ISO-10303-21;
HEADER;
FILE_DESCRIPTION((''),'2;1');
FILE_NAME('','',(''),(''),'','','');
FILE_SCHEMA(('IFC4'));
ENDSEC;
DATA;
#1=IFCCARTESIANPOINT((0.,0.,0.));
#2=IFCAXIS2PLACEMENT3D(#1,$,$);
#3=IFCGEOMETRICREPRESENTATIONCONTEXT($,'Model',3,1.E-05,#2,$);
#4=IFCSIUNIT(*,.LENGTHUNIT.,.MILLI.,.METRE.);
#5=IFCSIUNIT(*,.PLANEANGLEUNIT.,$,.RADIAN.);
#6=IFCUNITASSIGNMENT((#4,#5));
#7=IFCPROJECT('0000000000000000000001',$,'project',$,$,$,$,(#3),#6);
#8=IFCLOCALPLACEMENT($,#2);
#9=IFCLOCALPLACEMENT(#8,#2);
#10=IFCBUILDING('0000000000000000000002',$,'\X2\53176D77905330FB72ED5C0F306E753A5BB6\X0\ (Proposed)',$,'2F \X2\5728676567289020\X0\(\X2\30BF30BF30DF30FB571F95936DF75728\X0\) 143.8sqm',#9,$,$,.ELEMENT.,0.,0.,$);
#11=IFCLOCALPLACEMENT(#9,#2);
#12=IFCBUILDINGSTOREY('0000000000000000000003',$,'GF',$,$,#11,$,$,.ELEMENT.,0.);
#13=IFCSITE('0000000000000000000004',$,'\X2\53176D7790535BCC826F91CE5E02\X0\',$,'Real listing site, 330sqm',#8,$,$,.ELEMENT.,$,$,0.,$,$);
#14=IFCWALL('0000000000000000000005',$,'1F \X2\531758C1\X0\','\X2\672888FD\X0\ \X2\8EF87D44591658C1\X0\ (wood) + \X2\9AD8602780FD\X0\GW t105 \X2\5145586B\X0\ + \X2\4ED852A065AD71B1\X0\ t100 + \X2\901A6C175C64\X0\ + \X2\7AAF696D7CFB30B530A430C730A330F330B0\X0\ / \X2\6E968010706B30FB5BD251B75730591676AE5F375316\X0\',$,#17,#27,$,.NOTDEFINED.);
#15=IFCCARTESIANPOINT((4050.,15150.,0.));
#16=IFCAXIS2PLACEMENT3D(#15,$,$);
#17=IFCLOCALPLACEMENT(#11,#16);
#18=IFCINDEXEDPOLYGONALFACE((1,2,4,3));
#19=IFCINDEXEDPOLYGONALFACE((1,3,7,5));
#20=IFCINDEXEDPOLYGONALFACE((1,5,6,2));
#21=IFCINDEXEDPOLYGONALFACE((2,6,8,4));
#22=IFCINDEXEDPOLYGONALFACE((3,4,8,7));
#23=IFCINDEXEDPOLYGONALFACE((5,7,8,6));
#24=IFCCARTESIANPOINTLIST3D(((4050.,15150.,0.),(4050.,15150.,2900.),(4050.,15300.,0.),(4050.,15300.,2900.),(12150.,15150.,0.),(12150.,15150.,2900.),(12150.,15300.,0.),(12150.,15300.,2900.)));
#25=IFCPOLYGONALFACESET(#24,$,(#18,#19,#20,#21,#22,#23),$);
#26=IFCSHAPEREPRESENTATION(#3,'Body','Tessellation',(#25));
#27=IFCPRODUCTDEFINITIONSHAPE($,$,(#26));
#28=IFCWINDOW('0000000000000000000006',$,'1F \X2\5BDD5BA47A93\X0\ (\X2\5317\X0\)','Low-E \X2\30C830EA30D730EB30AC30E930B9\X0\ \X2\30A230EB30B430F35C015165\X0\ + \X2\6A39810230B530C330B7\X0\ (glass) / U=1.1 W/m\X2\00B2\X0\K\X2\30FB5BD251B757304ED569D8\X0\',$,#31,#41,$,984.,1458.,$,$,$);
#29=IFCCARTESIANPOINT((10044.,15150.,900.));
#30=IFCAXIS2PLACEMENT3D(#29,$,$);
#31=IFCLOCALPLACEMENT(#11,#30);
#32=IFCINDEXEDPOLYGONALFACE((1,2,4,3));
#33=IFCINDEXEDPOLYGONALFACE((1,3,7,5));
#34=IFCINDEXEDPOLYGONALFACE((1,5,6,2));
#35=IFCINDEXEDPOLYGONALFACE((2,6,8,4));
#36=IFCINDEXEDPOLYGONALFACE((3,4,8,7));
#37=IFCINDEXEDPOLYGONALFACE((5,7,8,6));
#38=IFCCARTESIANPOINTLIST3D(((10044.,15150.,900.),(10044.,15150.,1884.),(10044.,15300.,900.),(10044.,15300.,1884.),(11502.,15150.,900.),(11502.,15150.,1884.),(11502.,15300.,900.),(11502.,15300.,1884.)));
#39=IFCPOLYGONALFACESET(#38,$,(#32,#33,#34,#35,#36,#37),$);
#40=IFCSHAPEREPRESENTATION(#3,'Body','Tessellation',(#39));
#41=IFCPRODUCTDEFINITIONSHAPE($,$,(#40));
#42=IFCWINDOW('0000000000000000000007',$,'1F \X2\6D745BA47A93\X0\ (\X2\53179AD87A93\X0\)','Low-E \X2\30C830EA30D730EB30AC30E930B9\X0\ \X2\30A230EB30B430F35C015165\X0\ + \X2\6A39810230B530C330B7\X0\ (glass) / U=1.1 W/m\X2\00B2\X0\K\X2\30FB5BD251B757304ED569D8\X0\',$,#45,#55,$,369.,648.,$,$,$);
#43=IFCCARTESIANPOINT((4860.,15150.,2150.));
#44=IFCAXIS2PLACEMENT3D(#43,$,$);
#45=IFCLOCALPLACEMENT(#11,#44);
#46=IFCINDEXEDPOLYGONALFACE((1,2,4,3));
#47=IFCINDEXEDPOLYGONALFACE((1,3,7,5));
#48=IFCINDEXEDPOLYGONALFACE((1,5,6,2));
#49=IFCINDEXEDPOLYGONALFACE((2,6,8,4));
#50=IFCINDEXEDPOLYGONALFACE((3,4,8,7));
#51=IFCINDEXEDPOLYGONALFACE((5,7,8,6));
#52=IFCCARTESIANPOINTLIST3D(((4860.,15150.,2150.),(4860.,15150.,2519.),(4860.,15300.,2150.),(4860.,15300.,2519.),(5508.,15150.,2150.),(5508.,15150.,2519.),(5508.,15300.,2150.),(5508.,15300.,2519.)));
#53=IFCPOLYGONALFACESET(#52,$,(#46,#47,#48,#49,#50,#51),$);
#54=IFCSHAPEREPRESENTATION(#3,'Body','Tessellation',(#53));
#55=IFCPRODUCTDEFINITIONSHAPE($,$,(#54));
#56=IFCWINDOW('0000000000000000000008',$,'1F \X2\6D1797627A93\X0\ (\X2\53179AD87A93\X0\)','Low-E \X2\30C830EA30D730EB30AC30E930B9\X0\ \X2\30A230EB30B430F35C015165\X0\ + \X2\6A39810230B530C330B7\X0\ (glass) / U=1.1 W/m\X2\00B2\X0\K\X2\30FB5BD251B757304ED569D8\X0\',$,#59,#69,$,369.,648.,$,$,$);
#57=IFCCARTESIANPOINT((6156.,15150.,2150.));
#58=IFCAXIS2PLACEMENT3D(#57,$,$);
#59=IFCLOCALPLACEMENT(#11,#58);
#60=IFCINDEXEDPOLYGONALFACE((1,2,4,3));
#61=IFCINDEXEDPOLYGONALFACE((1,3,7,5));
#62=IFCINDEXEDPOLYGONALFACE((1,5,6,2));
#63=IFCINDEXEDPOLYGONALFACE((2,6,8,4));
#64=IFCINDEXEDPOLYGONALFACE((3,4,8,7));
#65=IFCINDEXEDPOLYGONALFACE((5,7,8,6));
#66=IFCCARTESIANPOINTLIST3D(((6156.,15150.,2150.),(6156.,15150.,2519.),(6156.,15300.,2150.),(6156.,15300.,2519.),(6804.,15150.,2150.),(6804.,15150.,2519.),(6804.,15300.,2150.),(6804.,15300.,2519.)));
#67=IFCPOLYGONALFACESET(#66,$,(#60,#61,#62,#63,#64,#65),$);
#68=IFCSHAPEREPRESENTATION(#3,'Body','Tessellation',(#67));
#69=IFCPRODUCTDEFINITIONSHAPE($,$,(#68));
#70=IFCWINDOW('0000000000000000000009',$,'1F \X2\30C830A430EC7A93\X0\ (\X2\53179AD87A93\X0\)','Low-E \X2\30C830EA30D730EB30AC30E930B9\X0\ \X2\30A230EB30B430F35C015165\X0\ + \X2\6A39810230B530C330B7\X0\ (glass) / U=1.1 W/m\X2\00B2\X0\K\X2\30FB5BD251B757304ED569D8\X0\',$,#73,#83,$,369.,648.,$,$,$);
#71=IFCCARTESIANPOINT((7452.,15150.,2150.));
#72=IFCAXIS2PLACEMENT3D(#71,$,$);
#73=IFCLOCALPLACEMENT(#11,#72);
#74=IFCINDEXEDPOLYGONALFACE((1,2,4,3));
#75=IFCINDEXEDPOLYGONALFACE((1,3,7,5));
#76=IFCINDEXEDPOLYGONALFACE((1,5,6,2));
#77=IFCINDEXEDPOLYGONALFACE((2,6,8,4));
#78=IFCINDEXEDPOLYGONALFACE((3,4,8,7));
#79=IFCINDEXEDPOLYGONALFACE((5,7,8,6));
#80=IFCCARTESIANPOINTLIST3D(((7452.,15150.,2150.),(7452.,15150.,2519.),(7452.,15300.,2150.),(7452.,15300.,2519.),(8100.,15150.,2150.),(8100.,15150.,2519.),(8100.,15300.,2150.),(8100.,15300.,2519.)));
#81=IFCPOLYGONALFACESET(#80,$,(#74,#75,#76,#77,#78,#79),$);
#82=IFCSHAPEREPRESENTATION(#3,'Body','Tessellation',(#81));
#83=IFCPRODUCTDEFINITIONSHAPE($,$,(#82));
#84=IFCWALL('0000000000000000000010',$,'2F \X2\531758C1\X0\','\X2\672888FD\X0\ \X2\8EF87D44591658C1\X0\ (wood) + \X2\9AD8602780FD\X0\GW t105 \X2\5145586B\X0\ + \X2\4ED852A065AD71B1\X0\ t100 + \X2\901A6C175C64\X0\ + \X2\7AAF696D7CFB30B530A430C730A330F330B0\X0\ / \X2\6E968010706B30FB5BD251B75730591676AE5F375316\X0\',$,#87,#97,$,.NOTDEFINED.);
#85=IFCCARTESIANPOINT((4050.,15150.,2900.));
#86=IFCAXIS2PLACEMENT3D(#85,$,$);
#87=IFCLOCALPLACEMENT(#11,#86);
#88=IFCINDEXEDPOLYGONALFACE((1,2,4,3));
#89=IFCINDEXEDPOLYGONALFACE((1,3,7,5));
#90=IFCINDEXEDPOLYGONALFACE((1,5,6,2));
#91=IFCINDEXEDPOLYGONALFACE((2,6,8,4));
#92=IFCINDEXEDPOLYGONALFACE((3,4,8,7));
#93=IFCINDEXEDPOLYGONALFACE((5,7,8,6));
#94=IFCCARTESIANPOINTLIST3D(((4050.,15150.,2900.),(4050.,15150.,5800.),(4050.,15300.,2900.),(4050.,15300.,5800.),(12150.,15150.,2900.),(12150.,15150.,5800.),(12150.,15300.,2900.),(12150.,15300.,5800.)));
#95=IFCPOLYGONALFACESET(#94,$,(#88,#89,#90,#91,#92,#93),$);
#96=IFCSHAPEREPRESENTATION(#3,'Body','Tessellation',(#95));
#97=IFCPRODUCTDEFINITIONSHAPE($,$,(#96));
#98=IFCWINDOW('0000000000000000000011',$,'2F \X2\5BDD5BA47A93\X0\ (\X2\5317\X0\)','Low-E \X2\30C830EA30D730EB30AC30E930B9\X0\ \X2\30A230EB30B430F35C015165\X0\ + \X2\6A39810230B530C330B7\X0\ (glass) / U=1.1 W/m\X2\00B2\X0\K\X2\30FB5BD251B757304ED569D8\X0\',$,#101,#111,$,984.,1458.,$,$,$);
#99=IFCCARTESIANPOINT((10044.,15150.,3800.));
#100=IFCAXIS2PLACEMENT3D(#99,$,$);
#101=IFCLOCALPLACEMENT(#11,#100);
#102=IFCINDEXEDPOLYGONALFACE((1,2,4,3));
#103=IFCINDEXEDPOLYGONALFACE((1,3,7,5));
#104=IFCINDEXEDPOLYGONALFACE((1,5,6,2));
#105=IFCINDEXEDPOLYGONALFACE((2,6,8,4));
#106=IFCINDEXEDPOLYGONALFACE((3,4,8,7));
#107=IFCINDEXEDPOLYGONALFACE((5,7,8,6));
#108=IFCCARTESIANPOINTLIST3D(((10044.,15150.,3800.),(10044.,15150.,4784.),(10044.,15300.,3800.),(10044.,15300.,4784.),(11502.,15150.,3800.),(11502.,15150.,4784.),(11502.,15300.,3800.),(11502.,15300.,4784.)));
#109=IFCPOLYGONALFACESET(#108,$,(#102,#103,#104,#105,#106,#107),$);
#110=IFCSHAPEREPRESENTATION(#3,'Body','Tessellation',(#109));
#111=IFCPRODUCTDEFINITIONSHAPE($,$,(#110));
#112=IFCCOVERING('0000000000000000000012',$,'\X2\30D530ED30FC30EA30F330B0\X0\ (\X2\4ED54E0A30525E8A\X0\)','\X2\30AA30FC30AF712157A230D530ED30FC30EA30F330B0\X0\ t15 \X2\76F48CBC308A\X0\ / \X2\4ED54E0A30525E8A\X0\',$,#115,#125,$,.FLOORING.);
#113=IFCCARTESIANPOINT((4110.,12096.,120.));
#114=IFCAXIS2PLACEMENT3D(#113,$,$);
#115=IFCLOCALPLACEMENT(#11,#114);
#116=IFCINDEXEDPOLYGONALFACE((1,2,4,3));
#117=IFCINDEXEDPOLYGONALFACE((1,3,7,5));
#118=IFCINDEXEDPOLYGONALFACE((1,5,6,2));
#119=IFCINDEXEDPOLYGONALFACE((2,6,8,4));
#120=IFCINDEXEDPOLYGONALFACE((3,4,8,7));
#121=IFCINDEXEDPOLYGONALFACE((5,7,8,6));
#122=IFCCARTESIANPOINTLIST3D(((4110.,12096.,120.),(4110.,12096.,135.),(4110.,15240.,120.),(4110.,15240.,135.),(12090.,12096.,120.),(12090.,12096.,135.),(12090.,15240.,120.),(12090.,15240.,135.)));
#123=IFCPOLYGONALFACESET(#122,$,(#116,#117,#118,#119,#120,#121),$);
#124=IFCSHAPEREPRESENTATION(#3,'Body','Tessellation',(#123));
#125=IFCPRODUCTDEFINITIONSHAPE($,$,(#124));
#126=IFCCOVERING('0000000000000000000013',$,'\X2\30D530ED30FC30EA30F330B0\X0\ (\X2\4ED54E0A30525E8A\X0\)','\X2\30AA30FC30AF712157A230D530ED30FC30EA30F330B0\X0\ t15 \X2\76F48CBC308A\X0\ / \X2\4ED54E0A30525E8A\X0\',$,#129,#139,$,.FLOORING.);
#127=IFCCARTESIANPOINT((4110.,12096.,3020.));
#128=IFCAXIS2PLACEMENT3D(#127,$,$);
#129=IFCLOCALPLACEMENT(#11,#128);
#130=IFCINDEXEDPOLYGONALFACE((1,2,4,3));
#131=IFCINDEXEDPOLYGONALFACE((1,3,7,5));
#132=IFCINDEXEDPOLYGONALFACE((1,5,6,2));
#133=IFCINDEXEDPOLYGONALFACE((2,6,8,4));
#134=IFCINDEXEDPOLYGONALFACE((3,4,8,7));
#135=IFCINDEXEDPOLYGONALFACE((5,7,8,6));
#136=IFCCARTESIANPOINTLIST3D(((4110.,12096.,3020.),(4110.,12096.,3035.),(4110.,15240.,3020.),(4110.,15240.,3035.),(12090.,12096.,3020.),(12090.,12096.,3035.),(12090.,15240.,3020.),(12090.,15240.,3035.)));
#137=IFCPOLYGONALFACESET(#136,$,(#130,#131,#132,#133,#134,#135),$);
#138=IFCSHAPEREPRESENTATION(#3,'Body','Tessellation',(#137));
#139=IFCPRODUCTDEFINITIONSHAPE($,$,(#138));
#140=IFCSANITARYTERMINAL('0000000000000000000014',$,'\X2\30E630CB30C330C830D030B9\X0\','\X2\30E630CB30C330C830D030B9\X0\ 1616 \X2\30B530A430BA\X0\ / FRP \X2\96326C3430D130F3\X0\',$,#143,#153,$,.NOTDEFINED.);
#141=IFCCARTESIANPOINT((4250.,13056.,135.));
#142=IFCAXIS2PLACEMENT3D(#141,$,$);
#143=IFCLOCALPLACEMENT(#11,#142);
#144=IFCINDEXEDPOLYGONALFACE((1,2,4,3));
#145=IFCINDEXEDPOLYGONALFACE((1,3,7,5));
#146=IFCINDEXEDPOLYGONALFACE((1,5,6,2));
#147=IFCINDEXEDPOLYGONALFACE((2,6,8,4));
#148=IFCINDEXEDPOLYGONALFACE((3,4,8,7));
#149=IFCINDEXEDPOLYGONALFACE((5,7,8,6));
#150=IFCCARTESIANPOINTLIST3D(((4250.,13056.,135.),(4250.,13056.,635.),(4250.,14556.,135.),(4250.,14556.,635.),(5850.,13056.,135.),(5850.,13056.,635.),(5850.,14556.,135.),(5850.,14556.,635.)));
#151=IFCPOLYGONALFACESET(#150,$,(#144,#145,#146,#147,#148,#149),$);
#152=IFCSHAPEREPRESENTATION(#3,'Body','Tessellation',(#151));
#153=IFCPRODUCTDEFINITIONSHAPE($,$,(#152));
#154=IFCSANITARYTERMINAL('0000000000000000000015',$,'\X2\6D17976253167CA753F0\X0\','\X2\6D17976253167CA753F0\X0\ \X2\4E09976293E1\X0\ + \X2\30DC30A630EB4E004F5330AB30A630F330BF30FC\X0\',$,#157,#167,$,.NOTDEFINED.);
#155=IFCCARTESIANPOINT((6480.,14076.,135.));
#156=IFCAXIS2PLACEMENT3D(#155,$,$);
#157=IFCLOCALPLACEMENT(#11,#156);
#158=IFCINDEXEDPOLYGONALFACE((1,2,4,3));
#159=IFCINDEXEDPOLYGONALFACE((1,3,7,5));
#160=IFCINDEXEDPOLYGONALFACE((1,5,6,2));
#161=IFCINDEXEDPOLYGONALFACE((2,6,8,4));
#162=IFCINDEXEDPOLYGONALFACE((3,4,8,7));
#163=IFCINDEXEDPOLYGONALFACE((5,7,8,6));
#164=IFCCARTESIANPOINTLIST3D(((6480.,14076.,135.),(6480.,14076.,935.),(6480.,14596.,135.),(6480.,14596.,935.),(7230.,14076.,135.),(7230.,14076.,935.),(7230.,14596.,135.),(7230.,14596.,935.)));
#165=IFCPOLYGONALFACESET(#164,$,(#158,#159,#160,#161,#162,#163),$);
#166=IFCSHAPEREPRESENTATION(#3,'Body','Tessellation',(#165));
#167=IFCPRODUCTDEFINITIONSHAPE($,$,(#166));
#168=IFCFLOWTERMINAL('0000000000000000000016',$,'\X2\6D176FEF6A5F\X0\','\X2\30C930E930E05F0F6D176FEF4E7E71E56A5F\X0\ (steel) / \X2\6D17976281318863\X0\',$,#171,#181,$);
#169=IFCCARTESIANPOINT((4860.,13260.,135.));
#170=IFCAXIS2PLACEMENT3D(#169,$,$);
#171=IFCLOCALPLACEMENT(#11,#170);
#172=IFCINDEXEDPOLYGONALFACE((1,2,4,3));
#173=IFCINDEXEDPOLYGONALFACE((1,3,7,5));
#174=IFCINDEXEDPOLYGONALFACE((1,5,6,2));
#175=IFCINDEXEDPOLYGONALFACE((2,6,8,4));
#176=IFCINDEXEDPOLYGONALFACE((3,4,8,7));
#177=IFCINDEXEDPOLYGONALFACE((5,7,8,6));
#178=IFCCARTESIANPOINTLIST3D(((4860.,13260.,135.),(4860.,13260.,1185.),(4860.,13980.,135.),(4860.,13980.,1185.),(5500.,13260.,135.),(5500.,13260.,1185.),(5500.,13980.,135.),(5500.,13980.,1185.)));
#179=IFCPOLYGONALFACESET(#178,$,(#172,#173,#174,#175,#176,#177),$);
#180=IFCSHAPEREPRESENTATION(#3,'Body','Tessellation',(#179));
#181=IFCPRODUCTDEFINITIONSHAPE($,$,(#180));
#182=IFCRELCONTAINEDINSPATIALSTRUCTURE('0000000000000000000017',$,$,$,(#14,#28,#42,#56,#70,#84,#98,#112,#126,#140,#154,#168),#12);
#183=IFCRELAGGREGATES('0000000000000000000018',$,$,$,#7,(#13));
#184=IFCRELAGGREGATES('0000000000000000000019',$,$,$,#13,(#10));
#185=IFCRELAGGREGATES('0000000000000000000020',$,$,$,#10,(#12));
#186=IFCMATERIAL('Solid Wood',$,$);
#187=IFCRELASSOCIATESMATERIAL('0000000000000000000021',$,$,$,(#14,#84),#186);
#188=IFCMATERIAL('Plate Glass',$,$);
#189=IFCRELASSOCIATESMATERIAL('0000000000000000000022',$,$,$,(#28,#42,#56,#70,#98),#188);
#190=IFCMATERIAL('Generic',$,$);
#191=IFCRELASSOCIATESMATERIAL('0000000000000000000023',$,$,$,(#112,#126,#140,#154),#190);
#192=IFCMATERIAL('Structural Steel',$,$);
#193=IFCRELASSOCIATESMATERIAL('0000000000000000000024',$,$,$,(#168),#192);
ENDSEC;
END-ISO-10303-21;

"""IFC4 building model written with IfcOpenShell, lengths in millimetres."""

from ifc_helpers import new_model, si_unit, frame, frame_2d, origin, place, context, project, spatial, rectangle, extrude, material, element, fill, save


model = new_model("IFC4")

# Units and contexts
model_context = context("Model", 3, precision=1e-05, world=origin())
ifc_project = project(units=[si_unit("LENGTHUNIT", "METRE", prefix="MILLI"), si_unit("PLANEANGLEUNIT", "RADIAN")], contexts=[model_context])

# Site, building, storey
site_placement = place(None, origin())
site = spatial("IfcSite", under=ifc_project, at=site_placement, Name="北海道富良野市", ObjectType="Real listing site, 330sqm", CompositionType="ELEMENT", RefElevation=0.0)
building_placement = place(site_placement, origin())
building = spatial("IfcBuilding", under=site, at=building_placement, Name="北海道・狭小の町家 (Proposed)", ObjectType="2F 在来木造(タタミ・土間混在) 143.8sqm", CompositionType="ELEMENT", ElevationOfRefHeight=0.0, ElevationOfTerrain=0.0)
storey_placement = place(building_placement, origin())
storey = spatial("IfcBuildingStorey", under=building, at=storey_placement, Name="GF", CompositionType="ELEMENT", Elevation=0.0)

# Shared definitions
ifc_material_1 = material(Name="Solid Wood")

# Wall, openings, windows
wall_1_placement = place(storey_placement, frame((4050.0, 15150.0, 0.0)))
wall_1 = element("IfcWall", 1, at=wall_1_placement, inside=storey, material=ifc_material_1, Name="1F 北壁", Description="木製 軸組外壁 (wood) + 高性能GW t105 充填 + 付加断熱 t100 + 通気層 + 窯業系サイディング / 準耐火・寒冷地外皮強化", PredefinedType="NOTDEFINED", context=model_context, shape_type="SweptSolid", body=[
    extrude(rectangle(XDim=8100.0, YDim=150.0, at=frame_2d((4050.0, 75.0))), frame((4050.0, 15150.0, 0.0)), (0.0, 0.0, 1.0), 2900.0),
])
opening_1_placement = place(storey_placement, frame((10044.0, 15150.0, 900.0)))
opening_1 = element("IfcOpeningElement", 2, at=opening_1_placement, cuts=wall_1, PredefinedType="NOTDEFINED", context=model_context, shape_type="SweptSolid", body=[
    extrude(rectangle(XDim=1458.0, YDim=150.0, at=frame_2d((729.0, 75.0))), frame((10044.0, 15150.0, 900.0)), (0.0, 0.0, 1.0), 984.0),
])
opening_2_placement = place(storey_placement, frame((4860.0, 15150.0, 2150.0)))
opening_2 = element("IfcOpeningElement", 3, at=opening_2_placement, cuts=wall_1, PredefinedType="NOTDEFINED", context=model_context, shape_type="SweptSolid", body=[
    extrude(rectangle(XDim=648.0, YDim=150.0, at=frame_2d((324.0, 75.0))), frame((4860.0, 15150.0, 2150.0)), (0.0, 0.0, 1.0), 369.0),
])
opening_3_placement = place(storey_placement, frame((6156.0, 15150.0, 2150.0)))
opening_3 = element("IfcOpeningElement", 4, at=opening_3_placement, cuts=wall_1, PredefinedType="NOTDEFINED", context=model_context, shape_type="SweptSolid", body=[
    extrude(rectangle(XDim=648.0, YDim=150.0, at=frame_2d((324.0, 75.0))), frame((6156.0, 15150.0, 2150.0)), (0.0, 0.0, 1.0), 369.0),
])
opening_4_placement = place(storey_placement, frame((7452.0, 15150.0, 2150.0)))
opening_4 = element("IfcOpeningElement", 5, at=opening_4_placement, cuts=wall_1, PredefinedType="NOTDEFINED", context=model_context, shape_type="SweptSolid", body=[
    extrude(rectangle(XDim=648.0, YDim=150.0, at=frame_2d((324.0, 75.0))), frame((7452.0, 15150.0, 2150.0)), (0.0, 0.0, 1.0), 369.0),
])
ifc_material_2 = material(Name="Plate Glass")
window_1_placement = place(storey_placement, frame((10044.0, 15150.0, 900.0)))
window_1 = element("IfcWindow", 6, at=window_1_placement, inside=storey, material=ifc_material_2, Name="1F 寝室窓 (北)", Description="Low-E トリプルガラス アルゴン封入 + 樹脂サッシ (glass) / U=1.1 W/m²K・寒冷地仕様", OverallHeight=984.0, OverallWidth=1458.0, context=model_context, shape_type="SweptSolid", body=[
    extrude(rectangle(XDim=1458.0, YDim=150.0, at=frame_2d((729.0, 75.0))), frame((10044.0, 15150.0, 900.0)), (0.0, 0.0, 1.0), 984.0),
])
fill(opening_1, window_1)
window_2_placement = place(storey_placement, frame((4860.0, 15150.0, 2150.0)))
window_2 = element("IfcWindow", 7, at=window_2_placement, inside=storey, material=ifc_material_2, Name="1F 浴室窓 (北高窓)", Description="Low-E トリプルガラス アルゴン封入 + 樹脂サッシ (glass) / U=1.1 W/m²K・寒冷地仕様", OverallHeight=369.0, OverallWidth=648.0, context=model_context, shape_type="SweptSolid", body=[
    extrude(rectangle(XDim=648.0, YDim=150.0, at=frame_2d((324.0, 75.0))), frame((4860.0, 15150.0, 2150.0)), (0.0, 0.0, 1.0), 369.0),
])
fill(opening_2, window_2)
window_3_placement = place(storey_placement, frame((6156.0, 15150.0, 2150.0)))
window_3 = element("IfcWindow", 8, at=window_3_placement, inside=storey, material=ifc_material_2, Name="1F 洗面窓 (北高窓)", Description="Low-E トリプルガラス アルゴン封入 + 樹脂サッシ (glass) / U=1.1 W/m²K・寒冷地仕様", OverallHeight=369.0, OverallWidth=648.0, context=model_context, shape_type="SweptSolid", body=[
    extrude(rectangle(XDim=648.0, YDim=150.0, at=frame_2d((324.0, 75.0))), frame((6156.0, 15150.0, 2150.0)), (0.0, 0.0, 1.0), 369.0),
])
fill(opening_3, window_3)
window_4_placement = place(storey_placement, frame((7452.0, 15150.0, 2150.0)))
window_4 = element("IfcWindow", 9, at=window_4_placement, inside=storey, material=ifc_material_2, Name="1F トイレ窓 (北高窓)", Description="Low-E トリプルガラス アルゴン封入 + 樹脂サッシ (glass) / U=1.1 W/m²K・寒冷地仕様", OverallHeight=369.0, OverallWidth=648.0, context=model_context, shape_type="SweptSolid", body=[
    extrude(rectangle(XDim=648.0, YDim=150.0, at=frame_2d((324.0, 75.0))), frame((7452.0, 15150.0, 2150.0)), (0.0, 0.0, 1.0), 369.0),
])
fill(opening_4, window_4)

# Wall, opening, window
wall_2_placement = place(storey_placement, frame((4050.0, 15150.0, 2900.0)))
wall_2 = element("IfcWall", 10, at=wall_2_placement, inside=storey, material=ifc_material_1, Name="2F 北壁", Description="木製 軸組外壁 (wood) + 高性能GW t105 充填 + 付加断熱 t100 + 通気層 + 窯業系サイディング / 準耐火・寒冷地外皮強化", PredefinedType="NOTDEFINED", context=model_context, shape_type="SweptSolid", body=[
    extrude(rectangle(XDim=8100.0, YDim=150.0, at=frame_2d((4050.0, 75.0))), frame((4050.0, 15150.0, 2900.0)), (0.0, 0.0, 1.0), 2900.0),
])
opening_5_placement = place(storey_placement, frame((10044.0, 15150.0, 3800.0)))
opening_5 = element("IfcOpeningElement", 11, at=opening_5_placement, cuts=wall_2, PredefinedType="NOTDEFINED", context=model_context, shape_type="SweptSolid", body=[
    extrude(rectangle(XDim=1458.0, YDim=150.0, at=frame_2d((729.0, 75.0))), frame((10044.0, 15150.0, 3800.0)), (0.0, 0.0, 1.0), 984.0),
])
window_5_placement = place(storey_placement, frame((10044.0, 15150.0, 3800.0)))
window_5 = element("IfcWindow", 12, at=window_5_placement, inside=storey, material=ifc_material_2, Name="2F 寝室窓 (北)", Description="Low-E トリプルガラス アルゴン封入 + 樹脂サッシ (glass) / U=1.1 W/m²K・寒冷地仕様", OverallHeight=984.0, OverallWidth=1458.0, context=model_context, shape_type="SweptSolid", body=[
    extrude(rectangle(XDim=1458.0, YDim=150.0, at=frame_2d((729.0, 75.0))), frame((10044.0, 15150.0, 3800.0)), (0.0, 0.0, 1.0), 984.0),
])
fill(opening_5, window_5)

# Coverings
ifc_material_3 = material(Name="Generic")
covering_1_placement = place(storey_placement, frame((4110.0, 12096.0, 120.0)))
element("IfcCovering", 13, at=covering_1_placement, inside=storey, material=ifc_material_3, Name="フローリング (仕上げ床)", Description="オーク無垢フローリング t15 直貼り / 仕上げ床", PredefinedType="FLOORING", context=model_context, shape_type="SweptSolid", body=[
    extrude(rectangle(XDim=7980.0, YDim=3144.0, at=frame_2d((3990.0, 1572.0))), frame((4110.0, 12096.0, 120.0)), (0.0, 0.0, 1.0), 15.0),
])
covering_2_placement = place(storey_placement, frame((4110.0, 12096.0, 3020.0)))
element("IfcCovering", 14, at=covering_2_placement, inside=storey, material=ifc_material_3, Name="フローリング (仕上げ床)", Description="オーク無垢フローリング t15 直貼り / 仕上げ床", PredefinedType="FLOORING", context=model_context, shape_type="SweptSolid", body=[
    extrude(rectangle(XDim=7980.0, YDim=3144.0, at=frame_2d((3990.0, 1572.0))), frame((4110.0, 12096.0, 3020.0)), (0.0, 0.0, 1.0), 15.0),
])

# Sanitary terminals
sanitary_terminal_1_placement = place(storey_placement, frame((4250.0, 13056.0, 135.0)))
element("IfcSanitaryTerminal", 15, at=sanitary_terminal_1_placement, inside=storey, material=ifc_material_3, Name="ユニットバス", Description="ユニットバス 1616 サイズ / FRP 防水パン", PredefinedType="NOTDEFINED", context=model_context, shape_type="SweptSolid", body=[
    extrude(rectangle(XDim=1600.0, YDim=1500.0, at=frame_2d((800.0, 750.0))), frame((4250.0, 13056.0, 135.0)), (0.0, 0.0, 1.0), 500.0),
])
sanitary_terminal_2_placement = place(storey_placement, frame((6480.0, 14076.0, 135.0)))
element("IfcSanitaryTerminal", 16, at=sanitary_terminal_2_placement, inside=storey, material=ifc_material_3, Name="洗面化粧台", Description="洗面化粧台 三面鏡 + ボウル一体カウンター", PredefinedType="NOTDEFINED", context=model_context, shape_type="SweptSolid", body=[
    extrude(rectangle(XDim=750.0, YDim=520.0, at=frame_2d((375.0, 260.0))), frame((6480.0, 14076.0, 135.0)), (0.0, 0.0, 1.0), 800.0),
])

# Flow terminal
ifc_material_4 = material(Name="Structural Steel")
flow_terminal_placement = place(storey_placement, frame((4860.0, 13260.0, 135.0)))
element("IfcFlowTerminal", 17, at=flow_terminal_placement, inside=storey, material=ifc_material_4, Name="洗濯機", Description="ドラム式洗濯乾燥機 (steel) / 洗面脱衣", context=model_context, shape_type="SweptSolid", body=[
    extrude(rectangle(XDim=640.0, YDim=720.0, at=frame_2d((320.0, 360.0))), frame((4860.0, 13260.0, 135.0)), (0.0, 0.0, 1.0), 1050.0),
])

save(model, "model.ifc")
